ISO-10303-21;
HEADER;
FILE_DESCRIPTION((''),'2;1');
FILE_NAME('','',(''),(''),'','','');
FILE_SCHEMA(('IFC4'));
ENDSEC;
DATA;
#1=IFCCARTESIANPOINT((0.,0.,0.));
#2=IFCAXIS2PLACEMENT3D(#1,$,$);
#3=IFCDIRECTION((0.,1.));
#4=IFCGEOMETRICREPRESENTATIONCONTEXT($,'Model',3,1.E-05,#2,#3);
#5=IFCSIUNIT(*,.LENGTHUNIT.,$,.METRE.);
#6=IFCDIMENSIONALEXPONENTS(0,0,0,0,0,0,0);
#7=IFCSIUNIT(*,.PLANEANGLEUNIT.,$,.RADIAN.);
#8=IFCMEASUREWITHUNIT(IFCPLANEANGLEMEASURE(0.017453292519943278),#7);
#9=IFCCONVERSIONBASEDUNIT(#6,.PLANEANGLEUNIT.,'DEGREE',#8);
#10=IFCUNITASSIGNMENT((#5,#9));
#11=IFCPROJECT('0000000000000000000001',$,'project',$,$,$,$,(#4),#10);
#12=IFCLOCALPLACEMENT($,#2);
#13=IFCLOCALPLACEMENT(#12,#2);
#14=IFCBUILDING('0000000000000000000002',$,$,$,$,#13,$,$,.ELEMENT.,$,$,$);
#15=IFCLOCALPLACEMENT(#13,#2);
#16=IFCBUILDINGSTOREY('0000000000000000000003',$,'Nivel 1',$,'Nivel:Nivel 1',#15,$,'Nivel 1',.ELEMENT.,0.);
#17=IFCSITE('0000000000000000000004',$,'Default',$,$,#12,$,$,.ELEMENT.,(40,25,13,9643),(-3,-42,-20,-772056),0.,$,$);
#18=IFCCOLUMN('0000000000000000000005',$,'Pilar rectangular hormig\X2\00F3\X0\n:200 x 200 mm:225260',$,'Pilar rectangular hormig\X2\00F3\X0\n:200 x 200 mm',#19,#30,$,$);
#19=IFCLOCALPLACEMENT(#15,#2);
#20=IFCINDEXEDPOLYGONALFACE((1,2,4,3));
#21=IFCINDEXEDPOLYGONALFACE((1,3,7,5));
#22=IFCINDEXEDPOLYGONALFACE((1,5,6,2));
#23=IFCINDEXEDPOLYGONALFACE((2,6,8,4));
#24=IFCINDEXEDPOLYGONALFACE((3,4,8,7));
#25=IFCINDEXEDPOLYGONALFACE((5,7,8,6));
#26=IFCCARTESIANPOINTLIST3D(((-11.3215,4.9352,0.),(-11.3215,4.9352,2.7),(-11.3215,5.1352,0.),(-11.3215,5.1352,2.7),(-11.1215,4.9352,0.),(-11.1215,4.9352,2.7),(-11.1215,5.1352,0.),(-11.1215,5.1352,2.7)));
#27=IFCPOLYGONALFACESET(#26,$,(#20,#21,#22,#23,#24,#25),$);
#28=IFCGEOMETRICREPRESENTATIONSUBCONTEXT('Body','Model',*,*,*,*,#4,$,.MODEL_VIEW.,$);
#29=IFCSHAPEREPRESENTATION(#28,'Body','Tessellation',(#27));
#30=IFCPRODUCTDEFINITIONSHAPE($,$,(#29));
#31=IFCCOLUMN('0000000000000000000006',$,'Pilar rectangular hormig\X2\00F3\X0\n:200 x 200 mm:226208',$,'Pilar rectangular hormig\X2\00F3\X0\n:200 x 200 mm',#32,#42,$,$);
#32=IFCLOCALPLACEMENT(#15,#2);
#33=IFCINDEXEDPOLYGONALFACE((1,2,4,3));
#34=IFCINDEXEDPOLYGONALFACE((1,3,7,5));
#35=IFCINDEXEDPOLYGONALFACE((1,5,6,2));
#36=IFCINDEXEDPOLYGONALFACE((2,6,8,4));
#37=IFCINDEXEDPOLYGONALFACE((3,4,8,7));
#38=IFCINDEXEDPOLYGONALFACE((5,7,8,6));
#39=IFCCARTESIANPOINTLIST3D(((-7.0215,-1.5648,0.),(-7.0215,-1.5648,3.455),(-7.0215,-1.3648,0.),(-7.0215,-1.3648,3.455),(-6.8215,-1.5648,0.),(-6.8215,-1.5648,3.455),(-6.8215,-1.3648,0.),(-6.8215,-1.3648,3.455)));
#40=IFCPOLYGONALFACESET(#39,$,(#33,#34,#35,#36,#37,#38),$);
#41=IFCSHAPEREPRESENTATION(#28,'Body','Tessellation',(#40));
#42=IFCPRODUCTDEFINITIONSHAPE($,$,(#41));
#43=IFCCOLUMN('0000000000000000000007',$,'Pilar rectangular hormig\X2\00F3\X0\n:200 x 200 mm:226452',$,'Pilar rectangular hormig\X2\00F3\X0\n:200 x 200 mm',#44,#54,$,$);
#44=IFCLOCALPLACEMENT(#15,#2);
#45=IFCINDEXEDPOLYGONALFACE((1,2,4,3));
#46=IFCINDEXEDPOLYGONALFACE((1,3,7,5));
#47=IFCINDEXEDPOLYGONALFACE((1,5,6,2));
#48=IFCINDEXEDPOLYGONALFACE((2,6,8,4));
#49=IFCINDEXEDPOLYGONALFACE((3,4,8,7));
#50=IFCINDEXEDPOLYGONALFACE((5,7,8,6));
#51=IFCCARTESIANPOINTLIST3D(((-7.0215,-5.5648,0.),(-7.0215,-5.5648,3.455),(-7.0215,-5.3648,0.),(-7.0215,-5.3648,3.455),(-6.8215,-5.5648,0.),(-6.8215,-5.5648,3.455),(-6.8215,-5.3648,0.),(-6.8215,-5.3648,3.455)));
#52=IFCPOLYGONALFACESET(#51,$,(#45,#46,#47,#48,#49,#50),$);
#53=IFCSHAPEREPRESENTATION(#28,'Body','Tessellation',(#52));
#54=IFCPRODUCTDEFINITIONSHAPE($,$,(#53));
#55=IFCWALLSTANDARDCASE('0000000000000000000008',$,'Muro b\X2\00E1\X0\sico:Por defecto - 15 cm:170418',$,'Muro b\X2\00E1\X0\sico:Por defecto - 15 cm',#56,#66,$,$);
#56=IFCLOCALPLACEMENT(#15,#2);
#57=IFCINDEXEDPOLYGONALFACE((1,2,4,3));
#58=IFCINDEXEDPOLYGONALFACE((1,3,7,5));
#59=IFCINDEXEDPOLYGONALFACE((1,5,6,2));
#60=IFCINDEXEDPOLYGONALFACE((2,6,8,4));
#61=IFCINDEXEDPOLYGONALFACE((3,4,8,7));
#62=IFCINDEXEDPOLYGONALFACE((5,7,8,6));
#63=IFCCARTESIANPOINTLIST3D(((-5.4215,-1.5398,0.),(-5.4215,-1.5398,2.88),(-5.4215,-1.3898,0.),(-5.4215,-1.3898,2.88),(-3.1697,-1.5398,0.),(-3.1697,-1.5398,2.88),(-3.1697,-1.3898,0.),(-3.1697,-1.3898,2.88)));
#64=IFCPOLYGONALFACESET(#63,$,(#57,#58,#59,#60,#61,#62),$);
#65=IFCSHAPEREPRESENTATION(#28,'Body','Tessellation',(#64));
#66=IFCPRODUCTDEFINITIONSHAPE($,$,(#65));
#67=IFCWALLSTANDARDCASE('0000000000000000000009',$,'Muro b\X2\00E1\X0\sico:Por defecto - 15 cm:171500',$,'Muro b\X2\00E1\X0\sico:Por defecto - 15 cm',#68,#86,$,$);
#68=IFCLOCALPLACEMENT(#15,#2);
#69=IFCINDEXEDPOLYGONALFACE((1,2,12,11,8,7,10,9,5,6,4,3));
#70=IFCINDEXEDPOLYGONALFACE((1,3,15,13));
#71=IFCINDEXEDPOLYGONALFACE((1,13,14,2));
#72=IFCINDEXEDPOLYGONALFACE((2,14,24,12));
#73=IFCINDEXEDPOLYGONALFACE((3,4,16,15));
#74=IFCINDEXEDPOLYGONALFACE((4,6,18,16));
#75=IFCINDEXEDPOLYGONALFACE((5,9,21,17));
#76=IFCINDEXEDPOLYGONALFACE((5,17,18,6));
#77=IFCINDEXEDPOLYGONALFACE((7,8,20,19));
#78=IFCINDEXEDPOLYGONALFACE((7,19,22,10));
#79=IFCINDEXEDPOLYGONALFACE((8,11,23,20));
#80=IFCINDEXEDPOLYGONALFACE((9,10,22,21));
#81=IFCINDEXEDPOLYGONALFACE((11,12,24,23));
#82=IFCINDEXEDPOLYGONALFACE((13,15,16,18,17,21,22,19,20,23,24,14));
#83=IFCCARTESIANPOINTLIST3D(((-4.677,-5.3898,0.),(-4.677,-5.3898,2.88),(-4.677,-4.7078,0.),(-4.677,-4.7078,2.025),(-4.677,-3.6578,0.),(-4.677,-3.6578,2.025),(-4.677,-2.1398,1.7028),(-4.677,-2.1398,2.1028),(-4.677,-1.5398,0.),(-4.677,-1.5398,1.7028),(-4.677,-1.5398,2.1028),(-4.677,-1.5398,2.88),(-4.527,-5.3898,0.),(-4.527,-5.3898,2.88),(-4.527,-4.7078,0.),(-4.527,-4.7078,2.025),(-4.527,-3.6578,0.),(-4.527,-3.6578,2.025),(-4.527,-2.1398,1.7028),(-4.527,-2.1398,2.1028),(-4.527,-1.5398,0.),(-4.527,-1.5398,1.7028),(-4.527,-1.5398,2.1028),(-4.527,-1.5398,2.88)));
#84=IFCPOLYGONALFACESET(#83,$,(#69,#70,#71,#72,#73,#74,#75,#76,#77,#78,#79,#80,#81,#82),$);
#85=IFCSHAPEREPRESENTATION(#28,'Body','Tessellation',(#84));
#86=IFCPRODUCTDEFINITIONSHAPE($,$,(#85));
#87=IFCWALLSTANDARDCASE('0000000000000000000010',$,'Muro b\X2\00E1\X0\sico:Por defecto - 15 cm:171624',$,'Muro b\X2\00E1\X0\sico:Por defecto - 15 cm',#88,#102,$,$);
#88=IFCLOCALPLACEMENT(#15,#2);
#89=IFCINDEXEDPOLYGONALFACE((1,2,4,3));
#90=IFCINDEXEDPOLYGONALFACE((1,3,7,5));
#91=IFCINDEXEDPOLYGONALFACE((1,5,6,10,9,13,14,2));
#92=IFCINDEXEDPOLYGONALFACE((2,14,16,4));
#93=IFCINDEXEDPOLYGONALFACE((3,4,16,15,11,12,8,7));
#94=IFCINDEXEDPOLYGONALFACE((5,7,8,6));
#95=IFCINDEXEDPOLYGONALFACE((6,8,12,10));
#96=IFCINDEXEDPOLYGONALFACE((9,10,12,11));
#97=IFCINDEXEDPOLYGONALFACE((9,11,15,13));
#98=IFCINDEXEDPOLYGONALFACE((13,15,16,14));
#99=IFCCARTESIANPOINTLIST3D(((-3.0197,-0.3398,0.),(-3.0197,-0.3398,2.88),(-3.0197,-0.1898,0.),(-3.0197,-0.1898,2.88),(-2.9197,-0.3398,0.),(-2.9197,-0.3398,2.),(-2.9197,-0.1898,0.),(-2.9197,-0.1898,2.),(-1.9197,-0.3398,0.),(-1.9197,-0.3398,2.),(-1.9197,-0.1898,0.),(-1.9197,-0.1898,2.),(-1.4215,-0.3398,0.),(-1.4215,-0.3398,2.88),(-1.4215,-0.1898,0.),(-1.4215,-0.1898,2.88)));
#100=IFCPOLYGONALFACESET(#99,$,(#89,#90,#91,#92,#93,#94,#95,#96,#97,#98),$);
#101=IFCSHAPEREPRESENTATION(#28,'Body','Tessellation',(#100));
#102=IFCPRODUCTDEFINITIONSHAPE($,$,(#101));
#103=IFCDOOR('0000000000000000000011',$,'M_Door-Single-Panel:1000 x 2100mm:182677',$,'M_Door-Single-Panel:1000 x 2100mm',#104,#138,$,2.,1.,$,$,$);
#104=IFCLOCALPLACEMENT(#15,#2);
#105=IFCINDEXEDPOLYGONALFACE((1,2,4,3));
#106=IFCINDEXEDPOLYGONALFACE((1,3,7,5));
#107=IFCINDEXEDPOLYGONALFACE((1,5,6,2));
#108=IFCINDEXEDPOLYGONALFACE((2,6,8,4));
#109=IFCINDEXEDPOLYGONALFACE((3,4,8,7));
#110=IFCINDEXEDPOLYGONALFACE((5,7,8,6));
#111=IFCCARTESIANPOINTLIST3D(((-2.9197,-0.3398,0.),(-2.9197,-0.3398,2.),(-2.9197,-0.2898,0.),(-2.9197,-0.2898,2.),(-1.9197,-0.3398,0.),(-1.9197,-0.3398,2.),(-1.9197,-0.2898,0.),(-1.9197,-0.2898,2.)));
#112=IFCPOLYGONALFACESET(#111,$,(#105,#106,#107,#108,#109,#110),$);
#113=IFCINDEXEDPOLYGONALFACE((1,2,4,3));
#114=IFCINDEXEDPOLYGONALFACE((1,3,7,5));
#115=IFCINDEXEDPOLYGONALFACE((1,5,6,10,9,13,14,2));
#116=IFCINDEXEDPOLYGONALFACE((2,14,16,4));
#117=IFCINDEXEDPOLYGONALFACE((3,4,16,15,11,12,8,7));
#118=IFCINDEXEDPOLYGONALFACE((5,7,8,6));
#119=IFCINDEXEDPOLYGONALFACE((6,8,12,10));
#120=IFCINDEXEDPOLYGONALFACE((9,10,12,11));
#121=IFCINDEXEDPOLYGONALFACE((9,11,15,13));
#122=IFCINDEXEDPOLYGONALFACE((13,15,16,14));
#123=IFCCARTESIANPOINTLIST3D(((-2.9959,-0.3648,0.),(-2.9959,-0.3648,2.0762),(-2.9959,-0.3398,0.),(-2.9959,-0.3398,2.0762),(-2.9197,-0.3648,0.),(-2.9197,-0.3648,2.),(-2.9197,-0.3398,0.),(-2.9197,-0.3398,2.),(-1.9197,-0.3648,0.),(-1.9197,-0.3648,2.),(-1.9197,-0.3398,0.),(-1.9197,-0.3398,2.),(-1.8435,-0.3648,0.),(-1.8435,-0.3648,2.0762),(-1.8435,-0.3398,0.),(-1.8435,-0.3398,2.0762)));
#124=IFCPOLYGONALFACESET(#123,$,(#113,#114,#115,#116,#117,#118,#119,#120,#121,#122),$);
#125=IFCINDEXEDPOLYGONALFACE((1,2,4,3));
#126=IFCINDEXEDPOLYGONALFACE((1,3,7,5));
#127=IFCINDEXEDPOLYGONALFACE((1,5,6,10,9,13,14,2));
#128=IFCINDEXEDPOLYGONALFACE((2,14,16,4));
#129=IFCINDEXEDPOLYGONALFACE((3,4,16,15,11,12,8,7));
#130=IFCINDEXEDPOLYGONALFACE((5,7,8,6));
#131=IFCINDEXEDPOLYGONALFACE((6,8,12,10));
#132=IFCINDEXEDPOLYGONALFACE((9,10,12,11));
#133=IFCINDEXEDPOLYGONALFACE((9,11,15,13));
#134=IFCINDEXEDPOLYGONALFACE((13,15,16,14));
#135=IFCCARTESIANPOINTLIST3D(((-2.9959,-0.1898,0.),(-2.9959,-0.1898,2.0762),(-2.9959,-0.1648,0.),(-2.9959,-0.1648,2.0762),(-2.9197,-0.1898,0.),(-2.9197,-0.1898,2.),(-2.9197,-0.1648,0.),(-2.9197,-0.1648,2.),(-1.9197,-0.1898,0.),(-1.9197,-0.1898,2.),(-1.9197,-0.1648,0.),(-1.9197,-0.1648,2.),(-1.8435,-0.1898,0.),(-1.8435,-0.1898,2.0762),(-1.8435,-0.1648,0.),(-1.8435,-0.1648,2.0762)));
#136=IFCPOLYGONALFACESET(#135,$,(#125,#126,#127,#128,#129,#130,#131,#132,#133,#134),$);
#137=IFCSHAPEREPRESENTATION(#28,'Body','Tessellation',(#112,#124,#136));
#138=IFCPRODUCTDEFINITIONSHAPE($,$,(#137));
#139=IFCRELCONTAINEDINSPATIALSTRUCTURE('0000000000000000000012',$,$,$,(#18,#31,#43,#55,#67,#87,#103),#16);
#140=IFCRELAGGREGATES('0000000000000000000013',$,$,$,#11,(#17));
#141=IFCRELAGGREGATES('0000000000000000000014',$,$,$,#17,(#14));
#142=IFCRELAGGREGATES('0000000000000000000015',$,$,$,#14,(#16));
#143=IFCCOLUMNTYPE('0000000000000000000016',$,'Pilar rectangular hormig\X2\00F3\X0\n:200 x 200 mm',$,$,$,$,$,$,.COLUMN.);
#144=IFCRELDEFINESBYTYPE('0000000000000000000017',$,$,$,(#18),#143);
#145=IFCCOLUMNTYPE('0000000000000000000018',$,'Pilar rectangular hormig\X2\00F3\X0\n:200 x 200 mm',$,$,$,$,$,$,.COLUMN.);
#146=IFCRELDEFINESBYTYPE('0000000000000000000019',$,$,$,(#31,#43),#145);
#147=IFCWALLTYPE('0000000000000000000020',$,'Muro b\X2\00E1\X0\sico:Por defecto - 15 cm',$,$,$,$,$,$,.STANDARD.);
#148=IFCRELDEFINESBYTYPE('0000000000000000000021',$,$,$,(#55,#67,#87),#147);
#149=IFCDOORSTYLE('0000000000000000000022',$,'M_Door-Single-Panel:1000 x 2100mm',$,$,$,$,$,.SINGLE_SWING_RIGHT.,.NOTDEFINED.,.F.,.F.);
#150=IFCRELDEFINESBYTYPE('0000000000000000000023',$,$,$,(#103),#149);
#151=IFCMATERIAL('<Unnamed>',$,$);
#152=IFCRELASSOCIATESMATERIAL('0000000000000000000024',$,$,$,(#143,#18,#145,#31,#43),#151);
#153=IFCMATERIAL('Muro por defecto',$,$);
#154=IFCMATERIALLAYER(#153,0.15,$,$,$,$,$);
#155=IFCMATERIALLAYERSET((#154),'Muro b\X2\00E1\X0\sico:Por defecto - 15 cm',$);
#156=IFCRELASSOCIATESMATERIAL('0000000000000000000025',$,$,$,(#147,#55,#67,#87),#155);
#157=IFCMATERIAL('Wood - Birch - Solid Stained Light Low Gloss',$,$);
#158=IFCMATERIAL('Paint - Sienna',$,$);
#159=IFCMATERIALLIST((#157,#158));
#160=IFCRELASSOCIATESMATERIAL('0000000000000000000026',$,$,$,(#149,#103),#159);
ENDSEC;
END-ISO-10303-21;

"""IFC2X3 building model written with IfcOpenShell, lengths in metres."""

from ifc_helpers import new_model, entity, si_unit, converted_unit, direction, frame, frame_2d, origin, origin_2d_with_axis, place, context, subcontext, project, spatial, polyline, rectangle, outline, extrude, clip, bounded_halfspace, source, transform, mapped, material, material_list, layer, layer_set, layer_usage, type_object, type_shapes, element, fill, save


model = new_model("IFC2X3")

# Units and contexts
model_context = context("Model", 3, precision=1e-05, world=origin(), true_north=direction((0.0, 1.0)))
body_context = subcontext(model_context, "Body", "Model", "MODEL_VIEW")
ifc_project = project(units=[si_unit("LENGTHUNIT", "METRE"), converted_unit("PLANEANGLEUNIT", "DEGREE", entity("IfcPlaneAngleMeasure", 0.017453292519943278), si_unit("PLANEANGLEUNIT", "RADIAN"), dimensions=[0, 0, 0, 0, 0, 0, 0])], contexts=[model_context])

# Site, building, storey
site_placement = place(None, origin())
site = spatial("IfcSite", under=ifc_project, at=site_placement, Name="Default", CompositionType="ELEMENT", RefLatitude=(40, 25, 13, 9643), RefLongitude=(-3, -42, -20, -772056), RefElevation=0.0)
building_placement = place(site_placement, origin())
building = spatial("IfcBuilding", under=site, at=building_placement, CompositionType="ELEMENT")
storey_placement = place(building_placement, origin())
storey = spatial("IfcBuildingStorey", under=building, at=storey_placement, Name="Nivel 1", ObjectType="Nivel:Nivel 1", LongName="Nivel 1", CompositionType="ELEMENT", Elevation=0.0)

# Columns
ifc_material_1 = material(Name="<Unnamed>")
column_type_1 = type_object("IfcColumnType", Name="Pilar rectangular hormigón:200 x 200 mm", PredefinedType="COLUMN", material=ifc_material_1)
shared_shape_1 = source(origin(), body_context, "Body", "SweptSolid", [
    extrude(rectangle(XDim=0.2, YDim=0.2, at=origin_2d_with_axis()), frame((0.0, 0.0, 0.0), z_axis=(0.0, 0.0, 1.0), x_axis=(-1.0, 0.0, 0.0)), (0.0, 0.0, 1.0), 2.7),
])
type_shapes(column_type_1, [shared_shape_1])
column_placement = place(storey_placement, frame((-11.2215, 5.0352, 0.0)))
element("IfcColumn", 1, at=column_placement, inside=storey, type_object=column_type_1, material=ifc_material_1, Name="Pilar rectangular hormigón:200 x 200 mm:225260", ObjectType="Pilar rectangular hormigón:200 x 200 mm", context=body_context, shape_type="MappedRepresentation", body=[
    mapped(shared_shape_1, transform((0.0, 0.0, 0.0), scale=1.0)),
])
column_type_2 = type_object("IfcColumnType", Name="Pilar rectangular hormigón:200 x 200 mm", PredefinedType="COLUMN", material=ifc_material_1)
shared_shape_2 = source(origin(), body_context, "Body", "SweptSolid", [
    extrude(rectangle(XDim=0.2, YDim=0.2, at=origin_2d_with_axis()), frame((0.0, 0.0, 0.0), z_axis=(0.0, 0.0, 1.0), x_axis=(-1.0, 0.0, 0.0)), (0.0, 0.0, 1.0), 3.455),
])
type_shapes(column_type_2, [shared_shape_2])
for number, where, name in (
    (2, (-6.9215, -1.4648, 0.0), "Pilar rectangular hormigón:200 x 200 mm:226208"),
    (3, (-6.9215, -5.4648, 0.0), "Pilar rectangular hormigón:200 x 200 mm:226452"),
):
    element("IfcColumn", number, at=place(storey_placement, frame(where)), inside=storey, type_object=column_type_2, material=ifc_material_1, Name=name, ObjectType="Pilar rectangular hormigón:200 x 200 mm", context=body_context, shape_type="MappedRepresentation", body=[
        mapped(shared_shape_2, transform((0.0, 0.0, 0.0), scale=1.0)),
    ])

# Shared definitions
ifc_material_2 = material(Name="Muro por defecto")
ifc_layer_1 = layer(ifc_material_2, 0.15)
ifc_layer_set_1 = layer_set([ifc_layer_1], Name="Muro básico:Por defecto - 15 cm")
wall_type = type_object("IfcWallType", Name="Muro básico:Por defecto - 15 cm", PredefinedType="STANDARD", material=ifc_layer_set_1)

# Wall
ifc_layer_usage_1 = layer_usage(ifc_layer_set_1, "AXIS2", "NEGATIVE", 0.075)
wall_1_placement = place(storey_placement, frame((-3.1697, -1.4648, 0.0), z_axis=(0.0, 0.0, 1.0), x_axis=(-1.0, 0.0, 0.0)))
element("IfcWallStandardCase", 4, at=wall_1_placement, inside=storey, type_object=wall_type, material=ifc_layer_usage_1, Name="Muro básico:Por defecto - 15 cm:170418", ObjectType="Muro básico:Por defecto - 15 cm", context=body_context, shape_type="Clipping", body=[
    clip(extrude(rectangle(XDim=2.2518, YDim=0.15, at=frame_2d((1.1259, 0.0), x_axis=(-1.0, 0.0))), origin(), (0.0, 0.0, 1.0), 2.88), bounded_halfspace(frame((0.0, -0.075, 2.88), z_axis=(0.0, 0.0, -1.0), x_axis=(-1.0, 0.0, 0.0)), True, frame((0.0, -0.075, 2.88)), polyline([(0.0, 0.0), (2.1018, 0.0), (2.2518, 0.0), (2.2518, 0.15), (1.5073, 0.15), (1.3573, 0.15), (0.0, 0.15), (0.0, 0.0)]))),
])

# Wall, openings
ifc_layer_usage_2 = layer_usage(ifc_layer_set_1, "AXIS2", "NEGATIVE", 0.075)
wall_2_placement = place(storey_placement, frame((-4.602, -5.3898, 0.0), z_axis=(0.0, 0.0, 1.0), x_axis=(0.0, 1.0, 0.0)))
wall_2 = element("IfcWallStandardCase", 5, at=wall_2_placement, inside=storey, type_object=wall_type, material=ifc_layer_usage_2, Name="Muro básico:Por defecto - 15 cm:171500", ObjectType="Muro básico:Por defecto - 15 cm", context=body_context, shape_type="Clipping", body=[
    clip(extrude(rectangle(XDim=3.85, YDim=0.15, at=frame_2d((1.925, 0.0), x_axis=(1.0, 0.0))), origin(), (0.0, 0.0, 1.0), 2.88), bounded_halfspace(frame((0.0, -0.075, 2.88), z_axis=(0.0, 0.0, -1.0), x_axis=(0.0, -1.0, 0.0)), True, frame((0.0, -0.075, 2.88)), polyline([(0.0, 0.0), (2.4139, 0.0), (2.5639, 0.0), (3.85, 0.0), (3.85, 0.15), (0.0, 0.15), (0.0, 0.0)]))),
])
opening_1_placement = place(wall_2_placement, frame((1.7319, 0.075, 0.0)))
element("IfcOpeningElement", 6, at=opening_1_placement, cuts=wall_2, ObjectType="Opening", context=body_context, shape_type="SweptSolid", body=[
    extrude(rectangle(XDim=2.025, YDim=1.05, at=frame_2d((1.0125, 0.525), x_axis=(1.0, 0.0))), frame((0.0, 0.0, 0.0), z_axis=(0.0, -1.0, 0.0), x_axis=(0.0, 0.0, 1.0)), (0.0, 0.0, 1.0), 0.15),
])
opening_2_placement = place(wall_2_placement, frame((3.25, -0.075, 1.7028)))
element("IfcOpeningElement", 7, at=opening_2_placement, cuts=wall_2, ObjectType="Opening", context=body_context, shape_type="SweptSolid", body=[
    extrude(rectangle(XDim=0.4, YDim=0.6, at=frame_2d((0.2, 0.3), x_axis=(1.0, 0.0))), frame((0.0, 0.0, 0.0), z_axis=(0.0, 1.0, 0.0), x_axis=(0.0, 0.0, 1.0)), (0.0, 0.0, 1.0), 0.15),
])

# Wall, opening, door
ifc_layer_usage_3 = layer_usage(ifc_layer_set_1, "AXIS2", "NEGATIVE", 0.075)
wall_3_placement = place(storey_placement, frame((-1.4215, -0.2648, 0.0), z_axis=(0.0, 0.0, 1.0), x_axis=(-1.0, 0.0, 0.0)))
wall_3 = element("IfcWallStandardCase", 8, at=wall_3_placement, inside=storey, type_object=wall_type, material=ifc_layer_usage_3, Name="Muro básico:Por defecto - 15 cm:171624", ObjectType="Muro básico:Por defecto - 15 cm", context=body_context, shape_type="Clipping", body=[
    clip(extrude(rectangle(XDim=1.5982, YDim=0.15, at=frame_2d((0.7991, 0.0), x_axis=(-1.0, 0.0))), origin(), (0.0, 0.0, 1.0), 2.88), bounded_halfspace(frame((0.0, -0.075, 2.88), z_axis=(0.0, 0.0, -1.0), x_axis=(-1.0, 0.0, 0.0)), True, frame((0.0, -0.075, 2.88)), polyline([(0.0, 0.0), (1.5982, 0.0), (1.5982, 0.15), (0.0, 0.15), (0.0, 0.0)]))),
])
opening_3_placement = place(wall_3_placement, frame((0.4982, -0.075, 0.0)))
opening_3 = element("IfcOpeningElement", 9, at=opening_3_placement, cuts=wall_3, ObjectType="Opening", context=body_context, shape_type="SweptSolid", body=[
    extrude(rectangle(XDim=1.0, YDim=2.0, at=frame_2d((1.0, 0.5), x_axis=(0.0, 1.0))), frame((0.0, 0.0, 0.0), z_axis=(0.0, 1.0, 0.0), x_axis=(0.0, 0.0, 1.0)), (0.0, 0.0, 1.0), 0.15),
])
ifc_material_3 = material(Name="Wood - Birch - Solid Stained Light Low Gloss")
ifc_material_4 = material(Name="Paint - Sienna")
ifc_material_list_1 = material_list([ifc_material_3, ifc_material_4])
door_style_1 = type_object("IfcDoorStyle", Name="M_Door-Single-Panel:1000 x 2100mm", ConstructionType="NOTDEFINED", OperationType="SINGLE_SWING_RIGHT", ParameterTakesPrecedence=False, Sizeable=False, material=ifc_material_list_1)
shared_shape_3 = source(origin(), body_context, "Body", "SweptSolid", [
    extrude(rectangle(XDim=0.05, YDim=1.0, at=origin_2d_with_axis()), frame((0.5, 0.125, 0.0), z_axis=(0.0, 0.0, 1.0), x_axis=(0.0, 1.0, 0.0)), (0.0, 0.0, 1.0), 2.0),
    extrude(outline(polyline([(-0.5762, -1.0571), (0.5762, -1.0571), (0.5762, 1.0191), (0.5, 1.0191), (0.5, -0.981), (-0.5, -0.981), (-0.5, 1.0191), (-0.5762, 1.0191), (-0.5762, -1.0571)])), frame((0.5, 0.15, 1.0191), z_axis=(0.0, 1.0, 0.0), x_axis=(1.0, 0.0, 0.0)), (0.0, 0.0, 1.0), 0.025),
    extrude(outline(polyline([(-1.0571, -0.5762), (1.019, -0.5762), (1.019, -0.5), (-0.9809, -0.5), (-0.9809, 0.5), (1.019, 0.5), (1.019, 0.5762), (-1.0571, 0.5762), (-1.0571, -0.5762)])), frame((0.5, -0.025, 1.019), z_axis=(0.0, 1.0, 0.0), x_axis=(0.0, 0.0, -1.0)), (0.0, 0.0, 1.0), 0.025),
])
type_shapes(door_style_1, [shared_shape_3])
door_1_placement = place(opening_3_placement, origin())
door_1 = element("IfcDoor", 10, at=door_1_placement, inside=storey, type_object=door_style_1, material=ifc_material_list_1, Name="M_Door-Single-Panel:1000 x 2100mm:182677", ObjectType="M_Door-Single-Panel:1000 x 2100mm", OverallHeight=2.0, OverallWidth=1.0, context=body_context, shape_type="MappedRepresentation", body=[
    mapped(shared_shape_3, transform((0.0, 0.0, 0.0), scale=1.0)),
])
fill(opening_3, door_1)

save(model, "model.ifc")
